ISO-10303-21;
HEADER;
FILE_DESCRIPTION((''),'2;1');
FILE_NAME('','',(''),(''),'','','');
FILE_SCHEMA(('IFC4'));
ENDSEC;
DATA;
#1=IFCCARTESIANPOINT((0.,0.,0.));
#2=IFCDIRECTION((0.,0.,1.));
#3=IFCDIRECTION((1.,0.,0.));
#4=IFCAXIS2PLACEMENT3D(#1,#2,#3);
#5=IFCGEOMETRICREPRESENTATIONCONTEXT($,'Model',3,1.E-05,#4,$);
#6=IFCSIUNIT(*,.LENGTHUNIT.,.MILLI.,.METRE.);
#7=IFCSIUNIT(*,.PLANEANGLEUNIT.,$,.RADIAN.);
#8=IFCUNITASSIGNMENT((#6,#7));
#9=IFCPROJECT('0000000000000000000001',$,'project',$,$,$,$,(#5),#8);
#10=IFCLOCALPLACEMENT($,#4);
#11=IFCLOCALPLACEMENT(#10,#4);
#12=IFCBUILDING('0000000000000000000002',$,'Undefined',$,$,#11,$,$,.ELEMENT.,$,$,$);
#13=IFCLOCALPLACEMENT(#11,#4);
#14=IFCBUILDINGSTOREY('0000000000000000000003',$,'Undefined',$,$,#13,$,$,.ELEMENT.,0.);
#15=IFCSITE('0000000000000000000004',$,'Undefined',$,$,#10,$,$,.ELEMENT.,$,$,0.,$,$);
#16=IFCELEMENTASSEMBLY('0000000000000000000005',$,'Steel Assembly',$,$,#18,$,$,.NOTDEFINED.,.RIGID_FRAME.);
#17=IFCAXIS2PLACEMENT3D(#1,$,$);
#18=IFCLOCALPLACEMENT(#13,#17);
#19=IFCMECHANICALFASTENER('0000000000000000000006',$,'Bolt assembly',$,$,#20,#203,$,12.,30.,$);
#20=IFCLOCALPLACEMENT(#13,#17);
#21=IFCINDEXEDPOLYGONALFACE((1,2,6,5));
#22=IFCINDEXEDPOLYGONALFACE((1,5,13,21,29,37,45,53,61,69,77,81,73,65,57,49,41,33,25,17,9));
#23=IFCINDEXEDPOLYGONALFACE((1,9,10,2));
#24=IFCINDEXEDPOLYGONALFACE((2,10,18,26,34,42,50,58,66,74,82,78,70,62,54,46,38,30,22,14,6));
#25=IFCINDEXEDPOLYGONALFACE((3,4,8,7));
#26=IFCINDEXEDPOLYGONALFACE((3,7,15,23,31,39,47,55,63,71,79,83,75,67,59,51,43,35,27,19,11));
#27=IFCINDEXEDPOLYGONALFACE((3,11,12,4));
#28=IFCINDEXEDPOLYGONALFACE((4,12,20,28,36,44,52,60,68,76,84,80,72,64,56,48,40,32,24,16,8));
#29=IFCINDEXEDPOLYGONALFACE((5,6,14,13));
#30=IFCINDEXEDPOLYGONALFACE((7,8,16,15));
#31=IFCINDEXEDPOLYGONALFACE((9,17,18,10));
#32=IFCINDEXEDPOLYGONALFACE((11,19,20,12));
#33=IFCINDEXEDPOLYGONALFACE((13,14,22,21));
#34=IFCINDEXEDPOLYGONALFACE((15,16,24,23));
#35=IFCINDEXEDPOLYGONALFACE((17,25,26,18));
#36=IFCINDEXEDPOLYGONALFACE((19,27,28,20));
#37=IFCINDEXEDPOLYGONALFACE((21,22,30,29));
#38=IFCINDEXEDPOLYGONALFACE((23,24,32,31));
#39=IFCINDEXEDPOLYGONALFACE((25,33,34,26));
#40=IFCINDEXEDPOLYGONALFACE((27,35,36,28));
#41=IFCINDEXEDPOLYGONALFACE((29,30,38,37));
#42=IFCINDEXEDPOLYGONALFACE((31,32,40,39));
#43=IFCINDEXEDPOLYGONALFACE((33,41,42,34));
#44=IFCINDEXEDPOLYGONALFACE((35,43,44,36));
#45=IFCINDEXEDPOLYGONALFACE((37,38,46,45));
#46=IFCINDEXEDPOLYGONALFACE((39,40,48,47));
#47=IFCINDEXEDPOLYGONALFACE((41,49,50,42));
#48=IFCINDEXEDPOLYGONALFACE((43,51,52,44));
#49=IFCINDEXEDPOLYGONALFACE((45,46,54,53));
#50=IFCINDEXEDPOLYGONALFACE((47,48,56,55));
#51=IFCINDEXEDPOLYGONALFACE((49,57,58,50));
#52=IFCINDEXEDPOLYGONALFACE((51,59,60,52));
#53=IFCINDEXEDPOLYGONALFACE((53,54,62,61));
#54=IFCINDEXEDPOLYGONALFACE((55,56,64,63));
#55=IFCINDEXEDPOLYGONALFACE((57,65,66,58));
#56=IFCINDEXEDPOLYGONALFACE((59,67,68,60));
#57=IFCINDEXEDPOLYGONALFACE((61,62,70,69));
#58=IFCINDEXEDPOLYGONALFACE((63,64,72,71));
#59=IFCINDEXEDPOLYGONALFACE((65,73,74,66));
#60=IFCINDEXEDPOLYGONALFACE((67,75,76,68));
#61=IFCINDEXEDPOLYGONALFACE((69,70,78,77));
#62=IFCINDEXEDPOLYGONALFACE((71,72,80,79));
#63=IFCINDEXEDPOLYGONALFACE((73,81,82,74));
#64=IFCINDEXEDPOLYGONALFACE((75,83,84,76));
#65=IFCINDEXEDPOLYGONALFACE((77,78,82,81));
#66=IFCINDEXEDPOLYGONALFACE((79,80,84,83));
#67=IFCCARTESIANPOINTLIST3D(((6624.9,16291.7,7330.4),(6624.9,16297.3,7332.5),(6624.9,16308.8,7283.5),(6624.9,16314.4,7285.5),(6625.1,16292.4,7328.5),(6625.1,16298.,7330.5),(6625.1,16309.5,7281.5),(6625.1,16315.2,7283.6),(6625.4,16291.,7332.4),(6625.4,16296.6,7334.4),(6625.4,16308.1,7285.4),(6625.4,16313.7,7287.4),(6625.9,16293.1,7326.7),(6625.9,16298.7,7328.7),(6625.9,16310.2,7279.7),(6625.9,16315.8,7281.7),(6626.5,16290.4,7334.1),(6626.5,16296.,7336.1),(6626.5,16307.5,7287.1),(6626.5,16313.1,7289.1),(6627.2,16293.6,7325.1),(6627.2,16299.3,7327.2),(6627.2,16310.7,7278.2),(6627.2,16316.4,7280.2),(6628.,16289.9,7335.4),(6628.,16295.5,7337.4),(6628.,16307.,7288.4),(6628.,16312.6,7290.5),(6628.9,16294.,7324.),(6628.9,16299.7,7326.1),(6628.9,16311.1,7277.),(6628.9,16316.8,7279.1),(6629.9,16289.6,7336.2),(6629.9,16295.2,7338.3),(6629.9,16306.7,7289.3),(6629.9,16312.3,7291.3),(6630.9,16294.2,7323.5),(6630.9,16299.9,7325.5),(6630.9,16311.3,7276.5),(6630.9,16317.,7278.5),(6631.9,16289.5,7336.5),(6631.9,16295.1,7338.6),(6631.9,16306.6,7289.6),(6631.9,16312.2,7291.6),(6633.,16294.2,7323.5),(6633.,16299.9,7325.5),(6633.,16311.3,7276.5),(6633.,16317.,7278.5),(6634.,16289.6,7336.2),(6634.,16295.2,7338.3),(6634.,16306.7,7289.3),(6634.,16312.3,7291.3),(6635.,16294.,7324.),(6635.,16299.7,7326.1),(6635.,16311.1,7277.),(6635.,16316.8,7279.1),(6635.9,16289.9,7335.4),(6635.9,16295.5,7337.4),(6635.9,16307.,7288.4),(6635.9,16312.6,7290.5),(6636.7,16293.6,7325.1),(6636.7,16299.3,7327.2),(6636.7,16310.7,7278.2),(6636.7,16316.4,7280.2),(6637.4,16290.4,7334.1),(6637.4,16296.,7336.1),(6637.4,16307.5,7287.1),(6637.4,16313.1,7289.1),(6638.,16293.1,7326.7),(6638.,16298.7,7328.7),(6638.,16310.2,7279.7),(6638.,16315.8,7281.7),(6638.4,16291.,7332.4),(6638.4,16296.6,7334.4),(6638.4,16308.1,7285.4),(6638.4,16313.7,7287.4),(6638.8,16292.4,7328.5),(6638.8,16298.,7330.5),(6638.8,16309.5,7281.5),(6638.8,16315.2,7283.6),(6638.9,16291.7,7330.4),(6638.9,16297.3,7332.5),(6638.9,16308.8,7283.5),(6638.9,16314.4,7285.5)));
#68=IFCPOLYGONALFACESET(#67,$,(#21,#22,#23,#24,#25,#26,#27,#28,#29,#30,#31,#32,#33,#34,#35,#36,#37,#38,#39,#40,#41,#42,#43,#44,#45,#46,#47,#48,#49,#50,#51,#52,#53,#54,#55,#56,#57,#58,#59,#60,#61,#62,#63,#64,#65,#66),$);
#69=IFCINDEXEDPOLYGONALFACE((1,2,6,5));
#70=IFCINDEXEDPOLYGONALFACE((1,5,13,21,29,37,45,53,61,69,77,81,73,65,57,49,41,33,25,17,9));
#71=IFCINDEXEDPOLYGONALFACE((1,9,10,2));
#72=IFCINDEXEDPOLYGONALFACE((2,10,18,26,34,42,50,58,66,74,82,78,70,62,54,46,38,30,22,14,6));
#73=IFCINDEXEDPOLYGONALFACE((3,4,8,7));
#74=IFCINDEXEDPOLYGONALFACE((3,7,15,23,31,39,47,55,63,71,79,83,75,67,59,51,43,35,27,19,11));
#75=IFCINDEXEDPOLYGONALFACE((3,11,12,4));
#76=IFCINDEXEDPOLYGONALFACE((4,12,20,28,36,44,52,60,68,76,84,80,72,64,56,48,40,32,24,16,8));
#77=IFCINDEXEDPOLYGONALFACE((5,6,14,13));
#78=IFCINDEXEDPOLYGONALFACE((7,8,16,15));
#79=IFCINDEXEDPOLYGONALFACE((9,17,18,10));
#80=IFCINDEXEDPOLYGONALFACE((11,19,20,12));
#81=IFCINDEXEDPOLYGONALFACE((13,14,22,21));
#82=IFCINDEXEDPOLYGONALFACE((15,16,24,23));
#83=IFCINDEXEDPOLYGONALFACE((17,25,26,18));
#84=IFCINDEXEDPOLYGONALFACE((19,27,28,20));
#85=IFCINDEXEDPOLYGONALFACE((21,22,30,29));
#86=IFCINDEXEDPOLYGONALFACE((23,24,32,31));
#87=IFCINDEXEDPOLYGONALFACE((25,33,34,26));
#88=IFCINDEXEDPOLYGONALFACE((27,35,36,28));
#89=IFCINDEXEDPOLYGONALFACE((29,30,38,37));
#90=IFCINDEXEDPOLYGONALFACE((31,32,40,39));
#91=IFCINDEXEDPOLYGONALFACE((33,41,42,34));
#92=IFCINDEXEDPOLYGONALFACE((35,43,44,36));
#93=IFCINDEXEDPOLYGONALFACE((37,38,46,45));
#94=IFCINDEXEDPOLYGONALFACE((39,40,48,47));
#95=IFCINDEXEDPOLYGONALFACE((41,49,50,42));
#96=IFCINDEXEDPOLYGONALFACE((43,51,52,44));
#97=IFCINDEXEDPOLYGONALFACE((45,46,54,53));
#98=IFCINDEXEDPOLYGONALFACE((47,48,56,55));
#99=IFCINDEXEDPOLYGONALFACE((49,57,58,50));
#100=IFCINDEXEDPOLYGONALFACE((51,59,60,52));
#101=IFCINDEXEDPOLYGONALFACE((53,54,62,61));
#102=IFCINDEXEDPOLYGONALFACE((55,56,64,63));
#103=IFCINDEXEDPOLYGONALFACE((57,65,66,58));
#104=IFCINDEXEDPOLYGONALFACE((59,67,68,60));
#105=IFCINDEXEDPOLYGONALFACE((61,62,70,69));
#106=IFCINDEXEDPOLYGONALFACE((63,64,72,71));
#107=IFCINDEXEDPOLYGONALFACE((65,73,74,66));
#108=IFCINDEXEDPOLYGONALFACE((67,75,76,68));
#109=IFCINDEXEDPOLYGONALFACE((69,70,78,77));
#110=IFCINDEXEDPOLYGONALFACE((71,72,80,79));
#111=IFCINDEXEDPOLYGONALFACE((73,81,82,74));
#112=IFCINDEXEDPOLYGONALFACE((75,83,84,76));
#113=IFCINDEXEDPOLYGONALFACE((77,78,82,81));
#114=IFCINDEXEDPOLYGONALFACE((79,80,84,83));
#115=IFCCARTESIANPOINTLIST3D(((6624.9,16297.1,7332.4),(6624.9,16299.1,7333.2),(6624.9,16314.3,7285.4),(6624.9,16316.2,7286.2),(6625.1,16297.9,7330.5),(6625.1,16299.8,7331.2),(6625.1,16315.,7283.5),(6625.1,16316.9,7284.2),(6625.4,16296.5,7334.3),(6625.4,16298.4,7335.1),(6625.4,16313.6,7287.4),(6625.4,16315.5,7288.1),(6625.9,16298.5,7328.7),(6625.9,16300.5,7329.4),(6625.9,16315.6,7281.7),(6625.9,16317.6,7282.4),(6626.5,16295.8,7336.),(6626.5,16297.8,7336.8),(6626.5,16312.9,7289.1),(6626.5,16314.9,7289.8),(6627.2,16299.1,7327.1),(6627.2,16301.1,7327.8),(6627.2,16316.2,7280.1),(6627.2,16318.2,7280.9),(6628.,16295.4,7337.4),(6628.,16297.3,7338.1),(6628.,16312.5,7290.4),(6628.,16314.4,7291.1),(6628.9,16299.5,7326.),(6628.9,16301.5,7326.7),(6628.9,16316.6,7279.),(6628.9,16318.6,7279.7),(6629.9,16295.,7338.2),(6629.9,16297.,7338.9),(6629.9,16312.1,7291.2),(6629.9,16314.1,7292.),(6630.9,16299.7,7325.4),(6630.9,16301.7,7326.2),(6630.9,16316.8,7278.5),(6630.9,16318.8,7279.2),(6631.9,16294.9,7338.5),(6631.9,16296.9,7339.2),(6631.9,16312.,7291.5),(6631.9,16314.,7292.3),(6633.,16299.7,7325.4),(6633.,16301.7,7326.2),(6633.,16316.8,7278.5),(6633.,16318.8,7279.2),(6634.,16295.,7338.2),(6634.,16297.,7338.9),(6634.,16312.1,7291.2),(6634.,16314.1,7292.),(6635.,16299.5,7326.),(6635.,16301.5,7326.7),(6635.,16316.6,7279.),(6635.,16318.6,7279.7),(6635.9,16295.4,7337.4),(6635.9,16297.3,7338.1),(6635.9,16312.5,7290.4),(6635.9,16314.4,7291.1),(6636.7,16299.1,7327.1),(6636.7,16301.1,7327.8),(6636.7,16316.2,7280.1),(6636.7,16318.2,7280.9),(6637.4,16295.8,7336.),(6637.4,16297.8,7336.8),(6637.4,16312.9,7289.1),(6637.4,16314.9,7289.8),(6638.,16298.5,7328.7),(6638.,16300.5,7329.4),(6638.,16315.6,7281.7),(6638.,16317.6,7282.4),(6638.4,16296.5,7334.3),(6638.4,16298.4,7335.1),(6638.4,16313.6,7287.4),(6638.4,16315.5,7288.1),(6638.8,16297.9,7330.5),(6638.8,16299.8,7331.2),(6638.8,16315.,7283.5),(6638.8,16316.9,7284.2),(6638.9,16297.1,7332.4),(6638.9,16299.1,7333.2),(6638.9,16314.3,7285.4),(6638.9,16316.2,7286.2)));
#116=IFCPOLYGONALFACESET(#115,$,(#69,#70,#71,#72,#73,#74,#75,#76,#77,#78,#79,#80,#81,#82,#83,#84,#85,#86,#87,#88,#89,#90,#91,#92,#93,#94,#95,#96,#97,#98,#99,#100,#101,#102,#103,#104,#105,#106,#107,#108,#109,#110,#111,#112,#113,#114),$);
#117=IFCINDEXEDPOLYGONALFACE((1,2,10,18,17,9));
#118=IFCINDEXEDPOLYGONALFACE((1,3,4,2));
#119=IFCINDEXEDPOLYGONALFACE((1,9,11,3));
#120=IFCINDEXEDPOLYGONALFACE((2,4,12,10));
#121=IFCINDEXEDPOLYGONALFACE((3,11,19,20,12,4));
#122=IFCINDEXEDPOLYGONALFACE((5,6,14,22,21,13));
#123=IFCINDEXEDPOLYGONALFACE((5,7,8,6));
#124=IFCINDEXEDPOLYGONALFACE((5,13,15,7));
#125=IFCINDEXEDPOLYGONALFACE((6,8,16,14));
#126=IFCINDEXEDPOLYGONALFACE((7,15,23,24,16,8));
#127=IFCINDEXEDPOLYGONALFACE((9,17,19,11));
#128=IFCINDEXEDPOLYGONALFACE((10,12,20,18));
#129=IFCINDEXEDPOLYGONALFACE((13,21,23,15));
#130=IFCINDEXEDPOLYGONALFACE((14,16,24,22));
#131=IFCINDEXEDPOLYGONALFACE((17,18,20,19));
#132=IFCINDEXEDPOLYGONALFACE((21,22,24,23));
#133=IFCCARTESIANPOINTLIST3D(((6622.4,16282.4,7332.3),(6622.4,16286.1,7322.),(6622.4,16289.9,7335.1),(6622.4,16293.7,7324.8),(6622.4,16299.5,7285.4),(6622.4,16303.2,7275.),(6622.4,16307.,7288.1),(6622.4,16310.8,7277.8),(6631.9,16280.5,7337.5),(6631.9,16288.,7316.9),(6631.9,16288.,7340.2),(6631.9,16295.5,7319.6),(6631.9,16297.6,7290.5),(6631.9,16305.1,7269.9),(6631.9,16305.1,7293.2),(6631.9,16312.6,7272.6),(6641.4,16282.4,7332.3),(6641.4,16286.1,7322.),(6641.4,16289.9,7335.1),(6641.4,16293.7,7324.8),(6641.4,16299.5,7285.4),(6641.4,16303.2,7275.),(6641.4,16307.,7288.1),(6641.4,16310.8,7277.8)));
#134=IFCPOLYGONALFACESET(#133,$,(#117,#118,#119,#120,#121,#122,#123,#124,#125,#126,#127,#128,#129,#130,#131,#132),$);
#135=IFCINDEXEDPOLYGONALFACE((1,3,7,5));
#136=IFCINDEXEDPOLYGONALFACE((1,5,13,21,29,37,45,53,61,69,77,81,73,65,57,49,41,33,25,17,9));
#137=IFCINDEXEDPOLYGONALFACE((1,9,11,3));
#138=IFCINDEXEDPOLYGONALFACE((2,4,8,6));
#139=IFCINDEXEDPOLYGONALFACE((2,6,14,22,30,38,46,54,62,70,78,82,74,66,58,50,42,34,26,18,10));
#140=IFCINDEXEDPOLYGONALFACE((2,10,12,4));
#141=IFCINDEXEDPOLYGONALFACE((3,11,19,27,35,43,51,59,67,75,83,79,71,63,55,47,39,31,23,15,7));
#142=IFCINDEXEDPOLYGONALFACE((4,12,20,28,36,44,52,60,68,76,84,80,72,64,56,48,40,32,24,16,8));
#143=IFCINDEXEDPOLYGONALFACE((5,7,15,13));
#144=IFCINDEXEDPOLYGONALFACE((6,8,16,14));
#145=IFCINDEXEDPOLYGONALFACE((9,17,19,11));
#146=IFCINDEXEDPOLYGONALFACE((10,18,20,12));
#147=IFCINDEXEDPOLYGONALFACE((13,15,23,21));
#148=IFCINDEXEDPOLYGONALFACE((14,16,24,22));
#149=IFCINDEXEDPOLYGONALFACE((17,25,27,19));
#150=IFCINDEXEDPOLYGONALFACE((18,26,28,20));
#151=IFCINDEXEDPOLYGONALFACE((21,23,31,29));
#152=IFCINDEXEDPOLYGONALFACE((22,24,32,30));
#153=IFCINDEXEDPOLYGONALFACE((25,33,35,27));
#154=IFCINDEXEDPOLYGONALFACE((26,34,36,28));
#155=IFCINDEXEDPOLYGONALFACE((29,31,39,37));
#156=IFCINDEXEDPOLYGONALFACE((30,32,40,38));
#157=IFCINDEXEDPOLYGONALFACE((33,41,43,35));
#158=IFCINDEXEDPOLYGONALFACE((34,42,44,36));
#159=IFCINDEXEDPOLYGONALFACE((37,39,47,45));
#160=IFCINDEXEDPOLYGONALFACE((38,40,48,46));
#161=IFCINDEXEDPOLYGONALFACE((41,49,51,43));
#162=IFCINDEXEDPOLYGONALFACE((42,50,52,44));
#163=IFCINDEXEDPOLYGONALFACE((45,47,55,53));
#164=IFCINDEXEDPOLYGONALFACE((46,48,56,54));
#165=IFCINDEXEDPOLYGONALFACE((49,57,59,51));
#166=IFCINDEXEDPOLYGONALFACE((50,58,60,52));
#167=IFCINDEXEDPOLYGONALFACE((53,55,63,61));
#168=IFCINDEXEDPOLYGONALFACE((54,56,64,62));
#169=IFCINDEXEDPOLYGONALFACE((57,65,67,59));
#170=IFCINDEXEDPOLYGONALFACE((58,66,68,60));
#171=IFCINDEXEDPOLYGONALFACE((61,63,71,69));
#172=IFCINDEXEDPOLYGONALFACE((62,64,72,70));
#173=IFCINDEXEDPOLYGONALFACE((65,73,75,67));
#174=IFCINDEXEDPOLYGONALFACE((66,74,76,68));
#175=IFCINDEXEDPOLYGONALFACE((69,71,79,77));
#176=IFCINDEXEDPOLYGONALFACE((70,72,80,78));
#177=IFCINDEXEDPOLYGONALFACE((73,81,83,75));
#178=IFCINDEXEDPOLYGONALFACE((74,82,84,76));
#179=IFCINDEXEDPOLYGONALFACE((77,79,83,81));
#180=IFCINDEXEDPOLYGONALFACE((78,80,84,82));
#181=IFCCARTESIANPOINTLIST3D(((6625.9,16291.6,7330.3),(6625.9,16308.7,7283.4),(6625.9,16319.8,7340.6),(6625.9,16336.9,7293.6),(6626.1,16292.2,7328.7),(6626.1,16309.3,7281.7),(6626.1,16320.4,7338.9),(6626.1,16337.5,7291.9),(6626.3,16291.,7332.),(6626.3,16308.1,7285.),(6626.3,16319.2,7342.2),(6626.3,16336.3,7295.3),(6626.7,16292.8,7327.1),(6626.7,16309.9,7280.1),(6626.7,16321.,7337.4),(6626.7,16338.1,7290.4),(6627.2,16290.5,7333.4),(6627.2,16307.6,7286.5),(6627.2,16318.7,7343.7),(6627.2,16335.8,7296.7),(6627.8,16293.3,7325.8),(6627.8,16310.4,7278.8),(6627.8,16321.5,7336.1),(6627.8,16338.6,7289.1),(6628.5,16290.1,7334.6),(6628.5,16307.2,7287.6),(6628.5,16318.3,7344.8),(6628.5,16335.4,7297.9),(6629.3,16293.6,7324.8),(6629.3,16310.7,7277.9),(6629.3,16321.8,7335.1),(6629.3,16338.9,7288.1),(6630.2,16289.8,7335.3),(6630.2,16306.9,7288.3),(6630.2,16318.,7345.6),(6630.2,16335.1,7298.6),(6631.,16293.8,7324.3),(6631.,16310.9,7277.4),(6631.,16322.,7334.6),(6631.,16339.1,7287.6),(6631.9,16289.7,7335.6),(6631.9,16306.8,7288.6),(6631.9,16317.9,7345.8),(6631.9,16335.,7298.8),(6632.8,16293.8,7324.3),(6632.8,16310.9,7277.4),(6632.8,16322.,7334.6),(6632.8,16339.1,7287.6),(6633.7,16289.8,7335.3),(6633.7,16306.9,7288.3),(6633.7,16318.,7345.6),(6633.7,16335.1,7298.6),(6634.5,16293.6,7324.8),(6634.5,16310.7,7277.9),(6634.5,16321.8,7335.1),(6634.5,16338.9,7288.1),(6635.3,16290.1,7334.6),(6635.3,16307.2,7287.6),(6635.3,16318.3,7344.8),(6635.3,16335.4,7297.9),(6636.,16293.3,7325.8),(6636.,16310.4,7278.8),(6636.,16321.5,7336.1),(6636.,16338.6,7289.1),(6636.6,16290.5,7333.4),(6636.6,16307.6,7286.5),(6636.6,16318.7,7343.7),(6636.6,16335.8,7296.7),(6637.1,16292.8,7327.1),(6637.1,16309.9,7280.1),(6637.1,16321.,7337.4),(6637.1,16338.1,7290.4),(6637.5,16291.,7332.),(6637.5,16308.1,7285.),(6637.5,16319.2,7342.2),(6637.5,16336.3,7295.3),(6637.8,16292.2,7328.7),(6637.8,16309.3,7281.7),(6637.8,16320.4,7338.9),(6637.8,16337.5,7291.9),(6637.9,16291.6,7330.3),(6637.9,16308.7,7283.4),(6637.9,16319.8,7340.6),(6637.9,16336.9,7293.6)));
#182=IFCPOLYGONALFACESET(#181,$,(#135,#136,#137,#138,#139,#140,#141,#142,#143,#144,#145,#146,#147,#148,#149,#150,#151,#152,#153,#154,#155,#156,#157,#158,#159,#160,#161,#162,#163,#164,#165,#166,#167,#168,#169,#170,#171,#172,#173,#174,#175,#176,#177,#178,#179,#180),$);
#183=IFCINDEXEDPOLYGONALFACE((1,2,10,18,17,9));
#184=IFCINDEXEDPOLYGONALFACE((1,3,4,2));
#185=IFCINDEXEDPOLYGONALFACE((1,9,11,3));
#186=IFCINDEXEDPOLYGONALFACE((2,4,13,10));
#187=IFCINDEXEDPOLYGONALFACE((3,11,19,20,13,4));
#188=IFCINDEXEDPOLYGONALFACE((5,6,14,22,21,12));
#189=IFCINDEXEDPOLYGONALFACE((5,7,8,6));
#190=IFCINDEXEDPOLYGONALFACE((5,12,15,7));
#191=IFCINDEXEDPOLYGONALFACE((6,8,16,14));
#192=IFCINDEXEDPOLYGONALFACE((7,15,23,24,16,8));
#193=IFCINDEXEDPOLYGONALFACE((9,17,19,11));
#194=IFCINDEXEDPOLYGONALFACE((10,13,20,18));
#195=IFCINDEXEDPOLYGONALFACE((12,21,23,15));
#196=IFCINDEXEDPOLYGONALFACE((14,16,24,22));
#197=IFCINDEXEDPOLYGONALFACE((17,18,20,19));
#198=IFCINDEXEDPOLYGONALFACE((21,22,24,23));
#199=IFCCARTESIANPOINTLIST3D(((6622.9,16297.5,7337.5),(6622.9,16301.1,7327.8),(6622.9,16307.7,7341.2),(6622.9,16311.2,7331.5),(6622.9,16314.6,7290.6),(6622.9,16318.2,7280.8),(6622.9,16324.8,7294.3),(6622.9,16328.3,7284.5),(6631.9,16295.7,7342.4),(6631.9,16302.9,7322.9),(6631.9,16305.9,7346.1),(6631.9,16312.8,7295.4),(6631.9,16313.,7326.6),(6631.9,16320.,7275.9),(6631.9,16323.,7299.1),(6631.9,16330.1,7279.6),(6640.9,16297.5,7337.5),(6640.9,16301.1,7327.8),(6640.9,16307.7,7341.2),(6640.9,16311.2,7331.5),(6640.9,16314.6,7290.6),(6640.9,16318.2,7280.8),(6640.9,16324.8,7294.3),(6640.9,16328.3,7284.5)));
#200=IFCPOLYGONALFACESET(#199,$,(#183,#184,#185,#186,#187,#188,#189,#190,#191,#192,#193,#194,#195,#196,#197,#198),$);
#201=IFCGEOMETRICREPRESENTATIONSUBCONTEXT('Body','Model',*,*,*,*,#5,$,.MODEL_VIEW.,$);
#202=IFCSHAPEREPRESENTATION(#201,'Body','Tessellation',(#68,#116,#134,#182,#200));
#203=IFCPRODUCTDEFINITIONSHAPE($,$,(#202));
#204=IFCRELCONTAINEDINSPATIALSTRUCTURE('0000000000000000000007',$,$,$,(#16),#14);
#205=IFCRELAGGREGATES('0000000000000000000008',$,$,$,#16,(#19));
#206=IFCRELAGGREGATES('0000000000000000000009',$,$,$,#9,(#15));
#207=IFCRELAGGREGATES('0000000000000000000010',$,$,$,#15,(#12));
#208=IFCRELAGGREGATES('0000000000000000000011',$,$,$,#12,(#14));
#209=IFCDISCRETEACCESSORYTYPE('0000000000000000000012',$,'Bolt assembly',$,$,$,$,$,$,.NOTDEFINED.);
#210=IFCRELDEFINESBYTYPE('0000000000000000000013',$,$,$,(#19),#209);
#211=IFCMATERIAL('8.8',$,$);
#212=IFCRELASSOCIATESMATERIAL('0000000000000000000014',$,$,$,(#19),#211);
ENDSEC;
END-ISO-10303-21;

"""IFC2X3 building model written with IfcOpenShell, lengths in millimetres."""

from ifc_helpers import new_model, si_unit, frame, origin_with_axes, origin_2d_with_axis, place, context, subcontext, project, spatial, polyline, circle, outline, extrude, source, transform, mapped, material, type_object, element, aggregate, save


model = new_model("IFC2X3")

# Units and contexts
model_context = context("Model", 3, precision=1e-05, world=origin_with_axes())
body_context = subcontext(model_context, "Body", "Model", "MODEL_VIEW")
ifc_project = project(units=[si_unit("LENGTHUNIT", "METRE", prefix="MILLI"), si_unit("PLANEANGLEUNIT", "RADIAN")], contexts=[model_context])

# Site, building, storey
site_placement = place(None, origin_with_axes())
site = spatial("IfcSite", under=ifc_project, at=site_placement, Name="Undefined", CompositionType="ELEMENT", RefElevation=0.0)
building_placement = place(site_placement, origin_with_axes())
building = spatial("IfcBuilding", under=site, at=building_placement, Name="Undefined", CompositionType="ELEMENT")
storey_placement = place(building_placement, origin_with_axes())
storey = spatial("IfcBuildingStorey", under=building, at=storey_placement, Name="Undefined", CompositionType="ELEMENT", Elevation=0.0)

# Element assembly, mechanical fastener
assembly_1_placement = place(storey_placement, origin_with_axes())
assembly_1 = element("IfcElementAssembly", 1, at=assembly_1_placement, inside=storey, Name="Steel Assembly", AssemblyPlace="NOTDEFINED", PredefinedType="RIGID_FRAME")
ifc_material_1 = material(Name="8.8")
discrete_accessory_type_1 = type_object("IfcDiscreteAccessoryType", Name="Bolt assembly")
shared_shape_1 = source(origin_with_axes(), body_context, "Body", "SweptSolid", [
    extrude(circle(Radius=7.0, at=origin_2d_with_axis()), frame((0.0, -5.9, 0.0), z_axis=(0.0, 1.0, 0.0), x_axis=(1.0, 0.0, 0.0)), (0.0, 0.0, 1.0), 6.0),
    extrude(circle(Radius=7.0, at=origin_2d_with_axis()), frame((0.0, -0.1, 0.0), z_axis=(0.0, 1.0, 0.0), x_axis=(1.0, 0.0, 0.0)), (0.0, 0.0, 1.0), 2.1),
    extrude(outline(polyline([(11.0, 0.0), (5.5, 9.5), (-5.5, 9.5), (-11.0, 0.0), (-5.5, -9.5), (5.5, -9.5), (11.0, 0.0)])), frame((0.0, -14.0, 0.0), z_axis=(0.0, 1.0, 0.0), x_axis=(1.0, 0.0, 0.0)), (0.0, 0.0, 1.0), 8.0),
    extrude(circle(Radius=6.0, at=origin_2d_with_axis()), frame((0.0, -6.0, 0.0), z_axis=(0.0, 1.0, 0.0), x_axis=(1.0, 0.0, 0.0)), (0.0, 0.0, 1.0), 30.0),
    extrude(outline(polyline([(10.4, 0.0), (5.2, 9.0), (-5.2, 9.0), (-10.4, 0.0), (-5.2, -9.0), (5.2, -9.0), (10.4, 0.0)])), frame((0.0, 2.0, 0.0), z_axis=(0.0, 1.0, 0.0), x_axis=(1.0, 0.0, 0.0)), (0.0, 0.0, 1.0), 10.8),
])
mechanical_fastener_1_placement = place(assembly_1_placement, frame((6631.9, 16314.5, 7285.0), z_axis=(-1.0, 0.0, 0.0), x_axis=(0.0, -0.34202, 0.939693)))
mechanical_fastener_1 = element("IfcMechanicalFastener", 2, at=mechanical_fastener_1_placement, type_object=discrete_accessory_type_1, material=ifc_material_1, Name="Bolt assembly", NominalDiameter=12.0, NominalLength=30.0, context=body_context, shape_type="MappedRepresentation", body=[
    mapped(shared_shape_1, transform((0.0, 0.0, 0.0))),
    mapped(shared_shape_1, transform((50.0, 0.0, 0.0))),
])

aggregate(assembly_1, [mechanical_fastener_1])

save(model, "model.ifc")
